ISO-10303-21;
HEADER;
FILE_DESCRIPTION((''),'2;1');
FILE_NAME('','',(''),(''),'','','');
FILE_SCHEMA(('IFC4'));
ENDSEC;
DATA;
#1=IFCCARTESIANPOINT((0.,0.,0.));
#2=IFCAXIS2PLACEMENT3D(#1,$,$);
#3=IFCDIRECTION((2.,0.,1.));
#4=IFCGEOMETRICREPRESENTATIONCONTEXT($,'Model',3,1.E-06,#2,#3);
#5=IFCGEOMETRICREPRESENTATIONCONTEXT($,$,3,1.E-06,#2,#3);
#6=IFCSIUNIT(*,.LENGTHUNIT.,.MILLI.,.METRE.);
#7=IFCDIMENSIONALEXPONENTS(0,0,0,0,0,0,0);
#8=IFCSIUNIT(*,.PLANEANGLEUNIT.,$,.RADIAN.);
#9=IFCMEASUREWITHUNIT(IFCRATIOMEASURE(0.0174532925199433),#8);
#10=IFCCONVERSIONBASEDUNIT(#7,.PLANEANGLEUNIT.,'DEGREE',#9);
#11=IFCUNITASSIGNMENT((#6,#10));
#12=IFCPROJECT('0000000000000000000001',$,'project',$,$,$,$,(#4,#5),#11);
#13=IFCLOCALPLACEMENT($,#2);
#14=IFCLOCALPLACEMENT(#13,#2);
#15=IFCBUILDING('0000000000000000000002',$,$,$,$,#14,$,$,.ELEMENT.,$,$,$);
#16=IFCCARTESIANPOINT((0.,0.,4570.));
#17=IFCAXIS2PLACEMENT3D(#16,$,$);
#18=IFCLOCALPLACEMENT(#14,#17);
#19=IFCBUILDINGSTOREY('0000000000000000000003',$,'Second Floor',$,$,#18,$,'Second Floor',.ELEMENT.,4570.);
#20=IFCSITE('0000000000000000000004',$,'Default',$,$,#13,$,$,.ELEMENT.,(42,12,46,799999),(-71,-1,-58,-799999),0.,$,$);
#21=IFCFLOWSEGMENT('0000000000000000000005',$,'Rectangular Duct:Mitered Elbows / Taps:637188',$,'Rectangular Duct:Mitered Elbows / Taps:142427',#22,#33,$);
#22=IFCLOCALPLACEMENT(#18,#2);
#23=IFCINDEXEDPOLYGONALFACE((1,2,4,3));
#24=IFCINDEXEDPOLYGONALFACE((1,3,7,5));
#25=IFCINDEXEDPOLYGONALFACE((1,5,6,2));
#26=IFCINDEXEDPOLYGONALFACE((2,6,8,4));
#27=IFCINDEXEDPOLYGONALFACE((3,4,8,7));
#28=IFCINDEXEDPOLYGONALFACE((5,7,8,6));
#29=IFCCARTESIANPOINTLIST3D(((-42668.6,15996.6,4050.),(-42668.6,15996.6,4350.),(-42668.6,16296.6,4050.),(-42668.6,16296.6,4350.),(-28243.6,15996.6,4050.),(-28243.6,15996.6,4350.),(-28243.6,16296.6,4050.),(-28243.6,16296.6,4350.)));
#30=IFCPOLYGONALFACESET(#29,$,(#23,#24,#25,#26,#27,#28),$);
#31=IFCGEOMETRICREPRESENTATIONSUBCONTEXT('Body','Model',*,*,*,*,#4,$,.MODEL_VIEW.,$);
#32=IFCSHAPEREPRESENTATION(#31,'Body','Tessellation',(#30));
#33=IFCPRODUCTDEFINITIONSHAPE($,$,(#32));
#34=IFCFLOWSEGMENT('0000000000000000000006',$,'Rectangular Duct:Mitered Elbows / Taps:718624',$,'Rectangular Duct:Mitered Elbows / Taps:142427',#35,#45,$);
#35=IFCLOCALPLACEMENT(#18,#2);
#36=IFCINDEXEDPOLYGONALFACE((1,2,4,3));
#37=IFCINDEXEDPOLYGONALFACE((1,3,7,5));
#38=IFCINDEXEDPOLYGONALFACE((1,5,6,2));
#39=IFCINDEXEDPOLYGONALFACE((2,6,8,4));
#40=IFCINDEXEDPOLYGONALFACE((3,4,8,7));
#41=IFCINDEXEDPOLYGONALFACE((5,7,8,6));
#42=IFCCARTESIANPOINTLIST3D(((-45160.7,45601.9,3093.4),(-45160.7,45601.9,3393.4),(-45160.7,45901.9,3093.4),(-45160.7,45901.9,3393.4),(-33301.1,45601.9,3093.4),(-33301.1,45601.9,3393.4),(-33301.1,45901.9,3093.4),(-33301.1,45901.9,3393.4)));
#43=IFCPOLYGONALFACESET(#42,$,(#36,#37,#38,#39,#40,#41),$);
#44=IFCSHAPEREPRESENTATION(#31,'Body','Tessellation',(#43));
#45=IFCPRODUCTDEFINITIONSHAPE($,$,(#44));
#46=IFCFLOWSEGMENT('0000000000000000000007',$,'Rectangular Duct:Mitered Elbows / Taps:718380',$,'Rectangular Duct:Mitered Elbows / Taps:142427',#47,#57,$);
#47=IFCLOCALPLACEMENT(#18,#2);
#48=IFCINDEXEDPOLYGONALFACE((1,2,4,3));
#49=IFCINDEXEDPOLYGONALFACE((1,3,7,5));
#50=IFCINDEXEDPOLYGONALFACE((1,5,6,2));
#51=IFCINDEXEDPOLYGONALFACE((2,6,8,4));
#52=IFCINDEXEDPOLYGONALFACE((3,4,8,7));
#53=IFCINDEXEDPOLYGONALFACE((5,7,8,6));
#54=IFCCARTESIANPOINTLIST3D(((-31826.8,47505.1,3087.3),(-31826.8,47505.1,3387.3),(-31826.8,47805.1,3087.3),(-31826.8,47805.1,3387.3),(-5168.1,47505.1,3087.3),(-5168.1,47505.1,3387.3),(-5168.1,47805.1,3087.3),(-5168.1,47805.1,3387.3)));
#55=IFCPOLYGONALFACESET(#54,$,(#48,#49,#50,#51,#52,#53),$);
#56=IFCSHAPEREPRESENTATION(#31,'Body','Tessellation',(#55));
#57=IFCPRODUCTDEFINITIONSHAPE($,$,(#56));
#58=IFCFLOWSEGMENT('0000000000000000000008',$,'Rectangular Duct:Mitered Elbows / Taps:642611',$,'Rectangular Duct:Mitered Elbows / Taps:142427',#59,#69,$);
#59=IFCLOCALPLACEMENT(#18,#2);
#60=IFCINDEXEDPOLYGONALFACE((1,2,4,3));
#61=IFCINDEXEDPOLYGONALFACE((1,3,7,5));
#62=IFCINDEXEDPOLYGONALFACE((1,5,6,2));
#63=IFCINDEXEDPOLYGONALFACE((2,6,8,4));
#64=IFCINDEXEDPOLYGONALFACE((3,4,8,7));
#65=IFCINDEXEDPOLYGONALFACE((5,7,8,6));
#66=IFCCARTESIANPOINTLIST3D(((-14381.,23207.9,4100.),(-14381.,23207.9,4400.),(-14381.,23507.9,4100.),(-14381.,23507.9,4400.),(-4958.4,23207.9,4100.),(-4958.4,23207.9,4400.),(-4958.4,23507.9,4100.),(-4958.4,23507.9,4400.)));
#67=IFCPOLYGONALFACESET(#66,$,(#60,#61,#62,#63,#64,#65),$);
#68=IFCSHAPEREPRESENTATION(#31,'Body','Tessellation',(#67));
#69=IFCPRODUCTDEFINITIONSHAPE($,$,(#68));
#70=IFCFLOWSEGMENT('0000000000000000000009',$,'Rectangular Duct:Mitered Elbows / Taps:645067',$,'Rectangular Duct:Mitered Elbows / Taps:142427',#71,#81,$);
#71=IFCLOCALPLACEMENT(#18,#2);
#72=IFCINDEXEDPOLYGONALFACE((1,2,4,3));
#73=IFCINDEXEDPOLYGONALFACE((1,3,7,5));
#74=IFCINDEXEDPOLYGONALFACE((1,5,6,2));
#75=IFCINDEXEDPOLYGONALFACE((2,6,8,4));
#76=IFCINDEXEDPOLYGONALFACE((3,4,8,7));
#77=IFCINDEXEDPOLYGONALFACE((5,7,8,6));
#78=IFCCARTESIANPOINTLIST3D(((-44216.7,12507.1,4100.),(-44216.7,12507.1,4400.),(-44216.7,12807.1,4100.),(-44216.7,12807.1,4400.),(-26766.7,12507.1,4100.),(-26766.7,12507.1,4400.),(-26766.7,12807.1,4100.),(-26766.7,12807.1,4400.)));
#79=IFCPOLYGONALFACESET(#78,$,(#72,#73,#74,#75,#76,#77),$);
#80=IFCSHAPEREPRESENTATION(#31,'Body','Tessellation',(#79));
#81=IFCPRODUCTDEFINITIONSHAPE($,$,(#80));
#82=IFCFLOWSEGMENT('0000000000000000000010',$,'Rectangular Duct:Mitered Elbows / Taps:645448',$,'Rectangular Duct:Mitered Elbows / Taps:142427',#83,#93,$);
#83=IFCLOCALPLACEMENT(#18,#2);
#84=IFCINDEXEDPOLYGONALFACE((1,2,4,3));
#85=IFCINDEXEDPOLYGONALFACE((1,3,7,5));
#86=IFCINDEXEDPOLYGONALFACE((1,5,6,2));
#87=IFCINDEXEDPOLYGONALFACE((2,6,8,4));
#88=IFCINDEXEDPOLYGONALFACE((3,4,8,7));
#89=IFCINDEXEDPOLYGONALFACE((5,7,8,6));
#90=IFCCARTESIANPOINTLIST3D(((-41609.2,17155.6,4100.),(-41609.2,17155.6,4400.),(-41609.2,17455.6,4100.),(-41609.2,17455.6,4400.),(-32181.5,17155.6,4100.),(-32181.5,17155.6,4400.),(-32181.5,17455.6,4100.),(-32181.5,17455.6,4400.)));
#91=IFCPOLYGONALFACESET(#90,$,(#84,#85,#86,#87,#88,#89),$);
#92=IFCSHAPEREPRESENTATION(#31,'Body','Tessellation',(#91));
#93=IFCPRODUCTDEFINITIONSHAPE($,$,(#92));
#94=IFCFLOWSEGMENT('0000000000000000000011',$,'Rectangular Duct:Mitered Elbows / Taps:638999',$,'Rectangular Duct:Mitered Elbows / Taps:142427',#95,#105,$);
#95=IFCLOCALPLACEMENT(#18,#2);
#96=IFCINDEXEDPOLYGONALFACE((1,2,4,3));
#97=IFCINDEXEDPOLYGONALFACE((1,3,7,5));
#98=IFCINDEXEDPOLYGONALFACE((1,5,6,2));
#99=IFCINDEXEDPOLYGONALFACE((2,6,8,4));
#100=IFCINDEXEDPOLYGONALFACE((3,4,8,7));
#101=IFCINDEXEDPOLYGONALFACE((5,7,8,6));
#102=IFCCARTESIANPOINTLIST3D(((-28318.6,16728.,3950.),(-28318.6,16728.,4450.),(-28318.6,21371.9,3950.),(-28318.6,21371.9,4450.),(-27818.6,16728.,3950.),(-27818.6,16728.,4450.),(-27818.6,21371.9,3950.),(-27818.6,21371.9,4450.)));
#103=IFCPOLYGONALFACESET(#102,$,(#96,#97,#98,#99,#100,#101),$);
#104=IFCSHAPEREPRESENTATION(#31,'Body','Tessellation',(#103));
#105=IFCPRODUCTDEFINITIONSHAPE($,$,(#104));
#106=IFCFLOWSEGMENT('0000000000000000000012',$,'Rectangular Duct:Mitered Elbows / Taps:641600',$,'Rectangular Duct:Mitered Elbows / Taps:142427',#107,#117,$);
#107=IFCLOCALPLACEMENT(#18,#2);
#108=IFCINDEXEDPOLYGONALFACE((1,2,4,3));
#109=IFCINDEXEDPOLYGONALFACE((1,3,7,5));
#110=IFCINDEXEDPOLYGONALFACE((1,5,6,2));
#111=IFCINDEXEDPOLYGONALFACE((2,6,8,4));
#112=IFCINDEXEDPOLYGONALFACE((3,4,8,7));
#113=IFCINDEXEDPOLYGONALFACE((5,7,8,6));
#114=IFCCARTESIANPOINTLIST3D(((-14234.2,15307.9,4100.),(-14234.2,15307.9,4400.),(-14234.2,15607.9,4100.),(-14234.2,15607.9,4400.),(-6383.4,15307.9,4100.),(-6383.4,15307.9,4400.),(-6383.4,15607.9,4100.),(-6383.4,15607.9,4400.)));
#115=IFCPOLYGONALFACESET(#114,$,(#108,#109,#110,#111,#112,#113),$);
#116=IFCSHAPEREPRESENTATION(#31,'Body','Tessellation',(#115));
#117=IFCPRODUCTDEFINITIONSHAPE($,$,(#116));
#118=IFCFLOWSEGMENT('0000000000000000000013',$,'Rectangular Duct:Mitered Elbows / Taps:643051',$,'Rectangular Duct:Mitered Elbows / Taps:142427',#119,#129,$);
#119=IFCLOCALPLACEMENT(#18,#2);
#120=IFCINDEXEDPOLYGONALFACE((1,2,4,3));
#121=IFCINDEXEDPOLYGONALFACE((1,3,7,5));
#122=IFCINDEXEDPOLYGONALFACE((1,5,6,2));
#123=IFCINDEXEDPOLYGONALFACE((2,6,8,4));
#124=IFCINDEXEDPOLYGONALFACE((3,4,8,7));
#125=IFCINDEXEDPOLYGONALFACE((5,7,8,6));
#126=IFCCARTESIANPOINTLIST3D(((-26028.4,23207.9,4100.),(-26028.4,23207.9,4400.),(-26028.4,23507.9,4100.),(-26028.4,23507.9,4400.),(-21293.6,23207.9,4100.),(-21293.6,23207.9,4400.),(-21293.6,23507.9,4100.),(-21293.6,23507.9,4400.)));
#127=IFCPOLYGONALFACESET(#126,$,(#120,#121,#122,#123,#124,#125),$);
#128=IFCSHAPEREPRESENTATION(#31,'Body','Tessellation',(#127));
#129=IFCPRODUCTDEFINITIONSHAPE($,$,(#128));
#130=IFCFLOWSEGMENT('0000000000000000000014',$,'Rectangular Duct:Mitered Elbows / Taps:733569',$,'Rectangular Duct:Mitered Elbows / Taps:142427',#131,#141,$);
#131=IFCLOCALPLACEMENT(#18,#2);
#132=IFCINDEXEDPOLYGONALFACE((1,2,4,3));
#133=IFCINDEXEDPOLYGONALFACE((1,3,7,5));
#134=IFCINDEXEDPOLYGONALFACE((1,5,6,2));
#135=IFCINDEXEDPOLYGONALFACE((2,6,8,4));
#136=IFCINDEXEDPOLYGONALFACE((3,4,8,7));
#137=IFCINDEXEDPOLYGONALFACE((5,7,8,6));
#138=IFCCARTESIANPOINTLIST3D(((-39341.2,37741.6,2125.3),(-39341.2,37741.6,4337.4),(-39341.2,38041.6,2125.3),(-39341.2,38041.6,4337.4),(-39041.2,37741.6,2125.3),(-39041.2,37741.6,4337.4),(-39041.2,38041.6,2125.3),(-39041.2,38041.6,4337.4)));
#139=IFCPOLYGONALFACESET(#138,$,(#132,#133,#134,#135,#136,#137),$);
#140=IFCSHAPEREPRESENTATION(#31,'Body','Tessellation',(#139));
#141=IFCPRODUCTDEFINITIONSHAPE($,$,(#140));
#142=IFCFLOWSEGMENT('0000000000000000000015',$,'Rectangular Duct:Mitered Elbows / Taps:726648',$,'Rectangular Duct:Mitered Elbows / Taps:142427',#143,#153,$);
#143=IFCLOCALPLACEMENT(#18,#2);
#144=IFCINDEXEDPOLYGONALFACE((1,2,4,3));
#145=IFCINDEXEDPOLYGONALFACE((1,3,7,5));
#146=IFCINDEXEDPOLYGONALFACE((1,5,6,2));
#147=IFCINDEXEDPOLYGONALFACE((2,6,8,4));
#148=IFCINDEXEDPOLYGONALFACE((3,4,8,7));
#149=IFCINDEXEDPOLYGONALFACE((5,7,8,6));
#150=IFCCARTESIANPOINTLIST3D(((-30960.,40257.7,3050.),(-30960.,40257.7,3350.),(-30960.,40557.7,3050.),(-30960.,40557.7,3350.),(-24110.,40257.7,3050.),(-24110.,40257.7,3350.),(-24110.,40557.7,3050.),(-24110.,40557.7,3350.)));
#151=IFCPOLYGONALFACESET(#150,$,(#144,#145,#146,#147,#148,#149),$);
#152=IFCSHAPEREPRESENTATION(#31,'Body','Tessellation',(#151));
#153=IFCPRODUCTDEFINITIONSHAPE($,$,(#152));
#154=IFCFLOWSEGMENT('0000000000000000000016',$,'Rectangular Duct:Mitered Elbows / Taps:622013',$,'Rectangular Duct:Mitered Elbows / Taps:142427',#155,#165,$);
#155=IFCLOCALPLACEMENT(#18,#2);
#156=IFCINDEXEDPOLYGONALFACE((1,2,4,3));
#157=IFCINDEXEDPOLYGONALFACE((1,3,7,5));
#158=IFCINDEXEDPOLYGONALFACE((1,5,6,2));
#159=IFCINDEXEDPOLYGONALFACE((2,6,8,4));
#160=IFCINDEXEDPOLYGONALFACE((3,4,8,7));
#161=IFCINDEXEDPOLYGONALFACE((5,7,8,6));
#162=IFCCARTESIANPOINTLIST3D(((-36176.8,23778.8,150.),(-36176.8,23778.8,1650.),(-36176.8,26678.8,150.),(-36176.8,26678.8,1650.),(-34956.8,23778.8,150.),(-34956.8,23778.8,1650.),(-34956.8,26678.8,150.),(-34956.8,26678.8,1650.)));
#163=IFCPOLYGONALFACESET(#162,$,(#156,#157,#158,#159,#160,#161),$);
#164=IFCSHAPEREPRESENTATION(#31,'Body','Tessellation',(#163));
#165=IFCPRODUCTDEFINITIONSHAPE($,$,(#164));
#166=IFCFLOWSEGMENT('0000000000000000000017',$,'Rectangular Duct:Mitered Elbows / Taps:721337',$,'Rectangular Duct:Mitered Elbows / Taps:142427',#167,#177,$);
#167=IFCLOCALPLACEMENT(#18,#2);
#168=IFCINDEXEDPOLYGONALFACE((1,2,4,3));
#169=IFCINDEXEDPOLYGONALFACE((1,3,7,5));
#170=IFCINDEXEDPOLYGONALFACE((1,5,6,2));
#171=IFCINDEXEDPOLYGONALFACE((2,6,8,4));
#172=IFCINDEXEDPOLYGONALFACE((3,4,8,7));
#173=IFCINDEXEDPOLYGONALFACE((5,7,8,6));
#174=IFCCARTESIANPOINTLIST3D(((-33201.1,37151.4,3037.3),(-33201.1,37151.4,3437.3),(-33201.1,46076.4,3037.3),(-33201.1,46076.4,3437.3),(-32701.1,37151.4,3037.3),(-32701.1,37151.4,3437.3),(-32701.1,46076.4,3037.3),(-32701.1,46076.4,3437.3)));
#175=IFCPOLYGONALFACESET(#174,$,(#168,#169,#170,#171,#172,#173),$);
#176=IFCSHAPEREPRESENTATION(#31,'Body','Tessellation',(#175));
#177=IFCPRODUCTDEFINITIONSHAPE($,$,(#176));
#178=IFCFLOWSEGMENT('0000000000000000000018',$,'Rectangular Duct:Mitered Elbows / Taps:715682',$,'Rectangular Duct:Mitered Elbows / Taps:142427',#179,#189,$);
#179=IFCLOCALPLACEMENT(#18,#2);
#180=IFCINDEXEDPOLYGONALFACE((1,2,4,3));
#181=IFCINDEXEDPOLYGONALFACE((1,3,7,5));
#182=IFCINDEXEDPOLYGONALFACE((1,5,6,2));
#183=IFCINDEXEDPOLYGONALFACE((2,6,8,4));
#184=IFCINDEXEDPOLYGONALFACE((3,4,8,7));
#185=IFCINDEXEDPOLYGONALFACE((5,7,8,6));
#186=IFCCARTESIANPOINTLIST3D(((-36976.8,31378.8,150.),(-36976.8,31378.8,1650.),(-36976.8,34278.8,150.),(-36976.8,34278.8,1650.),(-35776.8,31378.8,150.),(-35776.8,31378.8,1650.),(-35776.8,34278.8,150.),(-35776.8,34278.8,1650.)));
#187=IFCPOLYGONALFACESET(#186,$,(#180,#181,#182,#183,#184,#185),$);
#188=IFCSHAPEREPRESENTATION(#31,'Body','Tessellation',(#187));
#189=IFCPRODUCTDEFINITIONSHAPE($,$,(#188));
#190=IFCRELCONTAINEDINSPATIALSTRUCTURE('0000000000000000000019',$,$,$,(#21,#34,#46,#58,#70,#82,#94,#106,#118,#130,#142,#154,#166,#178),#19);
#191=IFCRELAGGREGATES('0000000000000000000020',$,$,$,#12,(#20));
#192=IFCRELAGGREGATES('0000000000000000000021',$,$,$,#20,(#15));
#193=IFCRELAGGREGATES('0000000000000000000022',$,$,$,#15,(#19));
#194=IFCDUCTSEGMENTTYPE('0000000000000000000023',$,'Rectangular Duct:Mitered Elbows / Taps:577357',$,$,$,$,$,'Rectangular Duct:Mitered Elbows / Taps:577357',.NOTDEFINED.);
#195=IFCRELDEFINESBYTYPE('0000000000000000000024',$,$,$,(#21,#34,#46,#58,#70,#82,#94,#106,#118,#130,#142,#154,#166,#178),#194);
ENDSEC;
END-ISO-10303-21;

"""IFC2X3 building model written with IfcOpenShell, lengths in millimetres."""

from ifc_helpers import new_model, entity, si_unit, converted_unit, direction, frame, frame_2d, origin, origin_2d_with_axis, place, context, subcontext, project, spatial, rectangle, extrude, type_object, element, save


model = new_model("IFC2X3")

# Units and contexts
model_context = context("Model", 3, precision=1e-06, world=origin(), true_north=direction((2.0, 0.0, 1.0)))
context_of_model = context(None, 3, precision=1e-06, world=origin(), true_north=direction((2.0, 0.0, 1.0)))
body_context = subcontext(model_context, "Body", "Model", "MODEL_VIEW")
ifc_project = project(units=[si_unit("LENGTHUNIT", "METRE", prefix="MILLI"), converted_unit("PLANEANGLEUNIT", "DEGREE", entity("IfcRatioMeasure", 0.0174532925199433), si_unit("PLANEANGLEUNIT", "RADIAN"), dimensions=[0, 0, 0, 0, 0, 0, 0])], contexts=[model_context, context_of_model])

# Site, building, storey
site_placement = place(None, origin())
site = spatial("IfcSite", under=ifc_project, at=site_placement, Name="Default", CompositionType="ELEMENT", RefLatitude=(42, 12, 46, 799999), RefLongitude=(-71, -1, -58, -799999), RefElevation=0.0)
building_placement = place(site_placement, origin())
building = spatial("IfcBuilding", under=site, at=building_placement, CompositionType="ELEMENT")
storey_placement = place(building_placement, frame((0.0, 0.0, 4570.0)))
storey = spatial("IfcBuildingStorey", under=building, at=storey_placement, Name="Second Floor", LongName="Second Floor", CompositionType="ELEMENT", Elevation=4570.0)

# Flow segments
duct_segment_type_1 = type_object("IfcDuctSegmentType", Name="Rectangular Duct:Mitered Elbows / Taps:577357", ElementType="Rectangular Duct:Mitered Elbows / Taps:577357", PredefinedType="NOTDEFINED")
flow_segment_1_placement = place(storey_placement, origin())
element("IfcFlowSegment", 1, at=flow_segment_1_placement, inside=storey, type_object=duct_segment_type_1, Name="Rectangular Duct:Mitered Elbows / Taps:637188", ObjectType="Rectangular Duct:Mitered Elbows / Taps:142427", context=body_context, shape_type="SweptSolid", body=[
    extrude(rectangle(XDim=14425.0, YDim=300.0, at=frame_2d((0.0, 0.0), x_axis=(1.0, 0.0))), frame((-35456.1, 16146.6, 4050.0)), (0.0, 0.0, 1.0), 300.0),
])
flow_segment_2_placement = place(storey_placement, origin())
element("IfcFlowSegment", 2, at=flow_segment_2_placement, inside=storey, type_object=duct_segment_type_1, Name="Rectangular Duct:Mitered Elbows / Taps:718624", ObjectType="Rectangular Duct:Mitered Elbows / Taps:142427", context=body_context, shape_type="SweptSolid", body=[
    extrude(rectangle(XDim=11859.6, YDim=300.0, at=frame_2d((0.0, 0.0), x_axis=(1.0, 0.0))), frame((-39230.9, 45751.9, 3093.4)), (0.0, 0.0, 1.0), 300.0),
])
flow_segment_3_placement = place(storey_placement, origin())
element("IfcFlowSegment", 3, at=flow_segment_3_placement, inside=storey, type_object=duct_segment_type_1, Name="Rectangular Duct:Mitered Elbows / Taps:718380", ObjectType="Rectangular Duct:Mitered Elbows / Taps:142427", context=body_context, shape_type="SweptSolid", body=[
    extrude(rectangle(XDim=26658.7, YDim=300.0, at=origin_2d_with_axis()), frame((-18497.4, 47655.1, 3087.3)), (0.0, 0.0, 1.0), 300.0),
])
flow_segment_4_placement = place(storey_placement, origin())
element("IfcFlowSegment", 4, at=flow_segment_4_placement, inside=storey, type_object=duct_segment_type_1, Name="Rectangular Duct:Mitered Elbows / Taps:642611", ObjectType="Rectangular Duct:Mitered Elbows / Taps:142427", context=body_context, shape_type="SweptSolid", body=[
    extrude(rectangle(XDim=9422.6, YDim=300.0, at=frame_2d((0.0, 0.0), x_axis=(1.0, 0.0))), frame((-9669.7, 23357.9, 4100.0), z_axis=(0.0, 0.0, 1.0), x_axis=(-1.0, 0.0, 0.0)), (0.0, 0.0, 1.0), 300.0),
])
flow_segment_5_placement = place(storey_placement, origin())
element("IfcFlowSegment", 5, at=flow_segment_5_placement, inside=storey, type_object=duct_segment_type_1, Name="Rectangular Duct:Mitered Elbows / Taps:645067", ObjectType="Rectangular Duct:Mitered Elbows / Taps:142427", context=body_context, shape_type="SweptSolid", body=[
    extrude(rectangle(XDim=17450.0, YDim=300.0, at=frame_2d((0.0, 0.0), x_axis=(1.0, 0.0))), frame((-35491.7, 12657.1, 4100.0)), (0.0, 0.0, 1.0), 300.0),
])
flow_segment_6_placement = place(storey_placement, origin())
element("IfcFlowSegment", 6, at=flow_segment_6_placement, inside=storey, type_object=duct_segment_type_1, Name="Rectangular Duct:Mitered Elbows / Taps:645448", ObjectType="Rectangular Duct:Mitered Elbows / Taps:142427", context=body_context, shape_type="SweptSolid", body=[
    extrude(rectangle(XDim=9427.7, YDim=300.0, at=frame_2d((0.0, 0.0), x_axis=(1.0, 0.0))), frame((-36895.3, 17305.6, 4100.0)), (0.0, 0.0, 1.0), 300.0),
])
flow_segment_7_placement = place(storey_placement, origin())
element("IfcFlowSegment", 7, at=flow_segment_7_placement, inside=storey, type_object=duct_segment_type_1, Name="Rectangular Duct:Mitered Elbows / Taps:638999", ObjectType="Rectangular Duct:Mitered Elbows / Taps:142427", context=body_context, shape_type="SweptSolid", body=[
    extrude(rectangle(XDim=4643.9, YDim=500.0, at=frame_2d((0.0, 0.0), x_axis=(1.0, 0.0))), frame((-28068.6, 19050.0, 3950.0), z_axis=(0.0, 0.0, 1.0), x_axis=(0.0, 1.0, 0.0)), (0.0, 0.0, 1.0), 500.0),
])
flow_segment_8_placement = place(storey_placement, origin())
element("IfcFlowSegment", 8, at=flow_segment_8_placement, inside=storey, type_object=duct_segment_type_1, Name="Rectangular Duct:Mitered Elbows / Taps:641600", ObjectType="Rectangular Duct:Mitered Elbows / Taps:142427", context=body_context, shape_type="SweptSolid", body=[
    extrude(rectangle(XDim=7850.8, YDim=300.0, at=frame_2d((0.0, 0.0), x_axis=(1.0, 0.0))), frame((-10308.8, 15457.9, 4100.0), z_axis=(0.0, 0.0, 1.0), x_axis=(-1.0, 0.0, 0.0)), (0.0, 0.0, 1.0), 300.0),
])
flow_segment_9_placement = place(storey_placement, origin())
element("IfcFlowSegment", 9, at=flow_segment_9_placement, inside=storey, type_object=duct_segment_type_1, Name="Rectangular Duct:Mitered Elbows / Taps:643051", ObjectType="Rectangular Duct:Mitered Elbows / Taps:142427", context=body_context, shape_type="SweptSolid", body=[
    extrude(rectangle(XDim=4734.8, YDim=300.0, at=frame_2d((0.0, 0.0), x_axis=(1.0, 0.0))), frame((-23661.0, 23357.9, 4100.0), z_axis=(0.0, 0.0, 1.0), x_axis=(-1.0, 0.0, 0.0)), (0.0, 0.0, 1.0), 300.0),
])
flow_segment_10_placement = place(storey_placement, origin())
element("IfcFlowSegment", 10, at=flow_segment_10_placement, inside=storey, type_object=duct_segment_type_1, Name="Rectangular Duct:Mitered Elbows / Taps:733569", ObjectType="Rectangular Duct:Mitered Elbows / Taps:142427", context=body_context, shape_type="SweptSolid", body=[
    extrude(rectangle(XDim=300.0, YDim=300.0, at=origin_2d_with_axis()), frame((-39191.2, 37891.6, 2125.3), z_axis=(0.0, 0.0, 1.0), x_axis=(0.0, 1.0, 0.0)), (0.0, 0.0, 1.0), 2212.1),
])
flow_segment_11_placement = place(storey_placement, origin())
element("IfcFlowSegment", 11, at=flow_segment_11_placement, inside=storey, type_object=duct_segment_type_1, Name="Rectangular Duct:Mitered Elbows / Taps:726648", ObjectType="Rectangular Duct:Mitered Elbows / Taps:142427", context=body_context, shape_type="SweptSolid", body=[
    extrude(rectangle(XDim=6850.0, YDim=300.0, at=frame_2d((0.0, 0.0), x_axis=(1.0, 0.0))), frame((-27535.0, 40407.7, 3050.0), z_axis=(0.0, 0.0, 1.0), x_axis=(-1.0, 0.0, 0.0)), (0.0, 0.0, 1.0), 300.0),
])
flow_segment_12_placement = place(storey_placement, origin())
element("IfcFlowSegment", 12, at=flow_segment_12_placement, inside=storey, type_object=duct_segment_type_1, Name="Rectangular Duct:Mitered Elbows / Taps:622013", ObjectType="Rectangular Duct:Mitered Elbows / Taps:142427", context=body_context, shape_type="SweptSolid", body=[
    extrude(rectangle(XDim=1220.0, YDim=2900.0, at=frame_2d((0.0, 0.0), x_axis=(1.0, 0.0))), frame((-35566.8, 25228.8, 150.0)), (0.0, 0.0, 1.0), 1500.0),
])
flow_segment_13_placement = place(storey_placement, origin())
element("IfcFlowSegment", 13, at=flow_segment_13_placement, inside=storey, type_object=duct_segment_type_1, Name="Rectangular Duct:Mitered Elbows / Taps:721337", ObjectType="Rectangular Duct:Mitered Elbows / Taps:142427", context=body_context, shape_type="SweptSolid", body=[
    extrude(rectangle(XDim=8925.0, YDim=500.0, at=frame_2d((0.0, 0.0), x_axis=(1.0, 0.0))), frame((-32951.1, 41613.9, 3037.3), z_axis=(0.0, 0.0, 1.0), x_axis=(0.0, -1.0, 0.0)), (0.0, 0.0, 1.0), 400.0),
])
flow_segment_14_placement = place(storey_placement, origin())
element("IfcFlowSegment", 14, at=flow_segment_14_placement, inside=storey, type_object=duct_segment_type_1, Name="Rectangular Duct:Mitered Elbows / Taps:715682", ObjectType="Rectangular Duct:Mitered Elbows / Taps:142427", context=body_context, shape_type="SweptSolid", body=[
    extrude(rectangle(XDim=1200.0, YDim=2900.0, at=frame_2d((0.0, 0.0), x_axis=(1.0, 0.0))), frame((-36376.8, 32828.8, 150.0)), (0.0, 0.0, 1.0), 1500.0),
])

save(model, "model.ifc")
